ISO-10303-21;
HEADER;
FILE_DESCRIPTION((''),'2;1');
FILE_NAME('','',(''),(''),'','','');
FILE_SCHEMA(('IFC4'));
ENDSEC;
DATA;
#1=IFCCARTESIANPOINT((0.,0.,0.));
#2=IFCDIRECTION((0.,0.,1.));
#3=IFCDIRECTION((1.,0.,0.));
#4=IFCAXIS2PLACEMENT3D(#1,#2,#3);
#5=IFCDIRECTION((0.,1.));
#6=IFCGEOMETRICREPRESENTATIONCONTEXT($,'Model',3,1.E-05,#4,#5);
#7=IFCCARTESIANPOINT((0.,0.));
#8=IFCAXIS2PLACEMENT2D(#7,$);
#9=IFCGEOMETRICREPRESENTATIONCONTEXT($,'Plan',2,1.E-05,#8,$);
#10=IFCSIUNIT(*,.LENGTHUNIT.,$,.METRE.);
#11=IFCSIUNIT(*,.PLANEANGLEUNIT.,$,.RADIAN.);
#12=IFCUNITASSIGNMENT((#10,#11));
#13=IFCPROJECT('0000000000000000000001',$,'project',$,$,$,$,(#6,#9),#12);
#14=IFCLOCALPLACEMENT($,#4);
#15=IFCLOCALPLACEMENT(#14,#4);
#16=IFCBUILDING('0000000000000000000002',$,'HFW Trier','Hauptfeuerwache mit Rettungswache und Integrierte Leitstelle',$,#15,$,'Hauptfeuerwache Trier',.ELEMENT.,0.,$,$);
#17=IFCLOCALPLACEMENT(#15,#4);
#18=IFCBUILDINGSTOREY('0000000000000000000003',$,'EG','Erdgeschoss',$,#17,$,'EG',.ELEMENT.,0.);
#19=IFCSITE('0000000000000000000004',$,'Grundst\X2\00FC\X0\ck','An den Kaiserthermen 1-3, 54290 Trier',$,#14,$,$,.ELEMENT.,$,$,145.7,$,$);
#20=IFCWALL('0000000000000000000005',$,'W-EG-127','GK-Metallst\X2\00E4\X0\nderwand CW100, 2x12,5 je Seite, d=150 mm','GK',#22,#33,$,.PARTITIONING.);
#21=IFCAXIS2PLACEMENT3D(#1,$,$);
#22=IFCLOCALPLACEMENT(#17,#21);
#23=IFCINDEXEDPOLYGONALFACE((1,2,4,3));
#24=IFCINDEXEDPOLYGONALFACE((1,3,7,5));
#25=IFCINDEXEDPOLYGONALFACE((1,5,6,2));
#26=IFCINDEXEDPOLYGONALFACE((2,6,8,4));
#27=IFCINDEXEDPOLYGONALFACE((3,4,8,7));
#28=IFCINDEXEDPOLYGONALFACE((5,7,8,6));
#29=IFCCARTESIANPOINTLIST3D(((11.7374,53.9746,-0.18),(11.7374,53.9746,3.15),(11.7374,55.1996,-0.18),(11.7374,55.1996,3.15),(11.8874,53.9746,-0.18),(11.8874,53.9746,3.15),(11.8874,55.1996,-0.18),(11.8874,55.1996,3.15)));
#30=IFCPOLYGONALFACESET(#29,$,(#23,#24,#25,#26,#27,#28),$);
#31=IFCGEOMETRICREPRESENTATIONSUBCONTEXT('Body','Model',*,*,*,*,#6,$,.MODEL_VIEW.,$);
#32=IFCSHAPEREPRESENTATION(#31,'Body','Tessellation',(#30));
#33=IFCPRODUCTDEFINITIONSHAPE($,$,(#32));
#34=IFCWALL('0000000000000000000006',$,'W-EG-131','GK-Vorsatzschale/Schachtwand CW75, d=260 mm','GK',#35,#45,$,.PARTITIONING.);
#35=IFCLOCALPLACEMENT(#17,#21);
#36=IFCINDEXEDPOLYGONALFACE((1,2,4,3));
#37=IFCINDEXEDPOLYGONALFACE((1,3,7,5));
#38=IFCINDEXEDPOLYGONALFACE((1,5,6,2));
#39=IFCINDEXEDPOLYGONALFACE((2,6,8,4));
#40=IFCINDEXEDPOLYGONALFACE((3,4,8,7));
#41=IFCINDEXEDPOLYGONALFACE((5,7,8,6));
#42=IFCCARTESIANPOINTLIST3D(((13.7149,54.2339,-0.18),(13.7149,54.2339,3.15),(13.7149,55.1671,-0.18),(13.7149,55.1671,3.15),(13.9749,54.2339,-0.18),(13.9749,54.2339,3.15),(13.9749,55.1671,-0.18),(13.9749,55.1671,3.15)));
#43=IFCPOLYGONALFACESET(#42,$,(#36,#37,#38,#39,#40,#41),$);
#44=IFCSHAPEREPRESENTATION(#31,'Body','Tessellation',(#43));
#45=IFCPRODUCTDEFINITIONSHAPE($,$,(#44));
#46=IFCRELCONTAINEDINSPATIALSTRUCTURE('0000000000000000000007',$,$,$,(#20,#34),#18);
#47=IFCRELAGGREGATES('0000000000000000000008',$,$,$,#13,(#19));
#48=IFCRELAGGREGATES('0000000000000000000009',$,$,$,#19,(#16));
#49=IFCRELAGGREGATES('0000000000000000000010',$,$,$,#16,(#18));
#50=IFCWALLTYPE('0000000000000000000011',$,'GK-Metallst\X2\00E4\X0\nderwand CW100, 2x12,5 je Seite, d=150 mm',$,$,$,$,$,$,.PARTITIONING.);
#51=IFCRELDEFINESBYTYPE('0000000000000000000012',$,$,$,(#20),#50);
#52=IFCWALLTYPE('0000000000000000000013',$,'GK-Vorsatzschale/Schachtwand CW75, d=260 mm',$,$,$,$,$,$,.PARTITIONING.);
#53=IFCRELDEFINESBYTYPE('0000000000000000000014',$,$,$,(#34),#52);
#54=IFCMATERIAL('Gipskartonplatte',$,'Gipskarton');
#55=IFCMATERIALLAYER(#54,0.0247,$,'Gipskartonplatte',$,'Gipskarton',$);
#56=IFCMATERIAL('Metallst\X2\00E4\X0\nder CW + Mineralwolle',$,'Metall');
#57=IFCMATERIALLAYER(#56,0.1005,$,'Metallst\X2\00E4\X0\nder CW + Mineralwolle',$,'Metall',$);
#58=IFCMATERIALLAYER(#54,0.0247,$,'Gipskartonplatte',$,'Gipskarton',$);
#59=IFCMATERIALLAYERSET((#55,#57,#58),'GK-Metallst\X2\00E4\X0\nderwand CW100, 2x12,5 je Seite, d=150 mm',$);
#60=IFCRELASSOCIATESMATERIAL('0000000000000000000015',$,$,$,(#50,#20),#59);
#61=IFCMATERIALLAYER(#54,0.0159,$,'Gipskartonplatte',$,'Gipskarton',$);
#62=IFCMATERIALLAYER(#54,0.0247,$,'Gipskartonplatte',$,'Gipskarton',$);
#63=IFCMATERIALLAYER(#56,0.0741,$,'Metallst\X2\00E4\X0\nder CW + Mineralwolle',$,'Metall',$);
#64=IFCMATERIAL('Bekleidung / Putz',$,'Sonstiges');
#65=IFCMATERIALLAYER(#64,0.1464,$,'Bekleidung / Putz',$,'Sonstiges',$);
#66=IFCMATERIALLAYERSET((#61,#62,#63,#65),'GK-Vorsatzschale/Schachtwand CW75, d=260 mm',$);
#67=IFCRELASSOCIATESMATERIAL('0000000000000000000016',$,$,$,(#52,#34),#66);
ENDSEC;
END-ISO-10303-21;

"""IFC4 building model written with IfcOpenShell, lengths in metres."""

from ifc_helpers import new_model, si_unit, direction, frame, frame_2d, origin_with_axes, origin_2d, place, context, subcontext, project, spatial, rectangle, extrude, material, layer, layer_set, layer_usage, type_object, element, save


model = new_model("IFC4")

# Units and contexts
model_context = context("Model", 3, precision=1e-05, world=origin_with_axes(), true_north=direction((0.0, 1.0)))
plan_context = context("Plan", 2, precision=1e-05, world=origin_2d())
body_context = subcontext(model_context, "Body", "Model", "MODEL_VIEW")
ifc_project = project(units=[si_unit("LENGTHUNIT", "METRE"), si_unit("PLANEANGLEUNIT", "RADIAN")], contexts=[model_context, plan_context])

# Site, building, storey
site_placement = place(None, origin_with_axes())
site = spatial("IfcSite", under=ifc_project, at=site_placement, Name="Grundstück", Description="An den Kaiserthermen 1-3, 54290 Trier", CompositionType="ELEMENT", RefElevation=145.7)
building_placement = place(site_placement, origin_with_axes())
building = spatial("IfcBuilding", under=site, at=building_placement, Name="HFW Trier", Description="Hauptfeuerwache mit Rettungswache und Integrierte Leitstelle", LongName="Hauptfeuerwache Trier", CompositionType="ELEMENT", ElevationOfRefHeight=0.0)
storey_placement = place(building_placement, origin_with_axes())
storey = spatial("IfcBuildingStorey", under=building, at=storey_placement, Name="EG", Description="Erdgeschoss", LongName="EG", CompositionType="ELEMENT", Elevation=0.0)

# Shared definitions
ifc_material_1 = material(Name="Gipskartonplatte", Category="Gipskarton")
ifc_material_2 = material(Name="Metallständer CW + Mineralwolle", Category="Metall")

# Shared definitions
ifc_material_3 = material(Name="Bekleidung / Putz", Category="Sonstiges")

# Walls
ifc_layer_1 = layer(ifc_material_1, 0.0247, Name="Gipskartonplatte", Category="Gipskarton")
ifc_layer_2 = layer(ifc_material_2, 0.1005, Name="Metallständer CW + Mineralwolle", Category="Metall")
ifc_layer_3 = layer(ifc_material_1, 0.0247, Name="Gipskartonplatte", Category="Gipskarton")
ifc_layer_set_1 = layer_set([ifc_layer_1, ifc_layer_2, ifc_layer_3], Name="GK-Metallständerwand CW100, 2x12,5 je Seite, d=150 mm")
ifc_layer_usage_1 = layer_usage(ifc_layer_set_1, "AXIS2", "POSITIVE", -0.075)
wall_type_1 = type_object("IfcWallType", Name="GK-Metallständerwand CW100, 2x12,5 je Seite, d=150 mm", PredefinedType="PARTITIONING", material=ifc_layer_set_1)
wall_1_placement = place(storey_placement, frame((11.8124, 55.1996, -0.18), z_axis=(0.0, 0.0, 1.0), x_axis=(0.0, -1.0, 0.0)))
element("IfcWall", 1, at=wall_1_placement, inside=storey, type_object=wall_type_1, material=ifc_layer_usage_1, Name="W-EG-127", Description="GK-Metallständerwand CW100, 2x12,5 je Seite, d=150 mm", ObjectType="GK", PredefinedType="PARTITIONING", context=body_context, shape_type="SweptSolid", body=[
    extrude(rectangle(XDim=1.225, YDim=0.15, at=frame_2d((0.6125, 0.0))), origin_with_axes(), (0.0, 0.0, 1.0), 3.33),
])
ifc_layer_4 = layer(ifc_material_1, 0.0159, Name="Gipskartonplatte", Category="Gipskarton")
ifc_layer_5 = layer(ifc_material_1, 0.0247, Name="Gipskartonplatte", Category="Gipskarton")
ifc_layer_6 = layer(ifc_material_2, 0.0741, Name="Metallständer CW + Mineralwolle", Category="Metall")
ifc_layer_7 = layer(ifc_material_3, 0.1464, Name="Bekleidung / Putz", Category="Sonstiges")
ifc_layer_set_2 = layer_set([ifc_layer_4, ifc_layer_5, ifc_layer_6, ifc_layer_7], Name="GK-Vorsatzschale/Schachtwand CW75, d=260 mm")
ifc_layer_usage_2 = layer_usage(ifc_layer_set_2, "AXIS2", "POSITIVE", -0.13)
wall_type_2 = type_object("IfcWallType", Name="GK-Vorsatzschale/Schachtwand CW75, d=260 mm", PredefinedType="PARTITIONING", material=ifc_layer_set_2)
wall_2_placement = place(storey_placement, frame((13.8449, 55.1671, -0.18), z_axis=(0.0, 0.0, 1.0), x_axis=(0.0, -1.0, 0.0)))
element("IfcWall", 2, at=wall_2_placement, inside=storey, type_object=wall_type_2, material=ifc_layer_usage_2, Name="W-EG-131", Description="GK-Vorsatzschale/Schachtwand CW75, d=260 mm", ObjectType="GK", PredefinedType="PARTITIONING", context=body_context, shape_type="SweptSolid", body=[
    extrude(rectangle(XDim=0.9332, YDim=0.26, at=frame_2d((0.4666, 0.0))), origin_with_axes(), (0.0, 0.0, 1.0), 3.33),
])

save(model, "model.ifc")
